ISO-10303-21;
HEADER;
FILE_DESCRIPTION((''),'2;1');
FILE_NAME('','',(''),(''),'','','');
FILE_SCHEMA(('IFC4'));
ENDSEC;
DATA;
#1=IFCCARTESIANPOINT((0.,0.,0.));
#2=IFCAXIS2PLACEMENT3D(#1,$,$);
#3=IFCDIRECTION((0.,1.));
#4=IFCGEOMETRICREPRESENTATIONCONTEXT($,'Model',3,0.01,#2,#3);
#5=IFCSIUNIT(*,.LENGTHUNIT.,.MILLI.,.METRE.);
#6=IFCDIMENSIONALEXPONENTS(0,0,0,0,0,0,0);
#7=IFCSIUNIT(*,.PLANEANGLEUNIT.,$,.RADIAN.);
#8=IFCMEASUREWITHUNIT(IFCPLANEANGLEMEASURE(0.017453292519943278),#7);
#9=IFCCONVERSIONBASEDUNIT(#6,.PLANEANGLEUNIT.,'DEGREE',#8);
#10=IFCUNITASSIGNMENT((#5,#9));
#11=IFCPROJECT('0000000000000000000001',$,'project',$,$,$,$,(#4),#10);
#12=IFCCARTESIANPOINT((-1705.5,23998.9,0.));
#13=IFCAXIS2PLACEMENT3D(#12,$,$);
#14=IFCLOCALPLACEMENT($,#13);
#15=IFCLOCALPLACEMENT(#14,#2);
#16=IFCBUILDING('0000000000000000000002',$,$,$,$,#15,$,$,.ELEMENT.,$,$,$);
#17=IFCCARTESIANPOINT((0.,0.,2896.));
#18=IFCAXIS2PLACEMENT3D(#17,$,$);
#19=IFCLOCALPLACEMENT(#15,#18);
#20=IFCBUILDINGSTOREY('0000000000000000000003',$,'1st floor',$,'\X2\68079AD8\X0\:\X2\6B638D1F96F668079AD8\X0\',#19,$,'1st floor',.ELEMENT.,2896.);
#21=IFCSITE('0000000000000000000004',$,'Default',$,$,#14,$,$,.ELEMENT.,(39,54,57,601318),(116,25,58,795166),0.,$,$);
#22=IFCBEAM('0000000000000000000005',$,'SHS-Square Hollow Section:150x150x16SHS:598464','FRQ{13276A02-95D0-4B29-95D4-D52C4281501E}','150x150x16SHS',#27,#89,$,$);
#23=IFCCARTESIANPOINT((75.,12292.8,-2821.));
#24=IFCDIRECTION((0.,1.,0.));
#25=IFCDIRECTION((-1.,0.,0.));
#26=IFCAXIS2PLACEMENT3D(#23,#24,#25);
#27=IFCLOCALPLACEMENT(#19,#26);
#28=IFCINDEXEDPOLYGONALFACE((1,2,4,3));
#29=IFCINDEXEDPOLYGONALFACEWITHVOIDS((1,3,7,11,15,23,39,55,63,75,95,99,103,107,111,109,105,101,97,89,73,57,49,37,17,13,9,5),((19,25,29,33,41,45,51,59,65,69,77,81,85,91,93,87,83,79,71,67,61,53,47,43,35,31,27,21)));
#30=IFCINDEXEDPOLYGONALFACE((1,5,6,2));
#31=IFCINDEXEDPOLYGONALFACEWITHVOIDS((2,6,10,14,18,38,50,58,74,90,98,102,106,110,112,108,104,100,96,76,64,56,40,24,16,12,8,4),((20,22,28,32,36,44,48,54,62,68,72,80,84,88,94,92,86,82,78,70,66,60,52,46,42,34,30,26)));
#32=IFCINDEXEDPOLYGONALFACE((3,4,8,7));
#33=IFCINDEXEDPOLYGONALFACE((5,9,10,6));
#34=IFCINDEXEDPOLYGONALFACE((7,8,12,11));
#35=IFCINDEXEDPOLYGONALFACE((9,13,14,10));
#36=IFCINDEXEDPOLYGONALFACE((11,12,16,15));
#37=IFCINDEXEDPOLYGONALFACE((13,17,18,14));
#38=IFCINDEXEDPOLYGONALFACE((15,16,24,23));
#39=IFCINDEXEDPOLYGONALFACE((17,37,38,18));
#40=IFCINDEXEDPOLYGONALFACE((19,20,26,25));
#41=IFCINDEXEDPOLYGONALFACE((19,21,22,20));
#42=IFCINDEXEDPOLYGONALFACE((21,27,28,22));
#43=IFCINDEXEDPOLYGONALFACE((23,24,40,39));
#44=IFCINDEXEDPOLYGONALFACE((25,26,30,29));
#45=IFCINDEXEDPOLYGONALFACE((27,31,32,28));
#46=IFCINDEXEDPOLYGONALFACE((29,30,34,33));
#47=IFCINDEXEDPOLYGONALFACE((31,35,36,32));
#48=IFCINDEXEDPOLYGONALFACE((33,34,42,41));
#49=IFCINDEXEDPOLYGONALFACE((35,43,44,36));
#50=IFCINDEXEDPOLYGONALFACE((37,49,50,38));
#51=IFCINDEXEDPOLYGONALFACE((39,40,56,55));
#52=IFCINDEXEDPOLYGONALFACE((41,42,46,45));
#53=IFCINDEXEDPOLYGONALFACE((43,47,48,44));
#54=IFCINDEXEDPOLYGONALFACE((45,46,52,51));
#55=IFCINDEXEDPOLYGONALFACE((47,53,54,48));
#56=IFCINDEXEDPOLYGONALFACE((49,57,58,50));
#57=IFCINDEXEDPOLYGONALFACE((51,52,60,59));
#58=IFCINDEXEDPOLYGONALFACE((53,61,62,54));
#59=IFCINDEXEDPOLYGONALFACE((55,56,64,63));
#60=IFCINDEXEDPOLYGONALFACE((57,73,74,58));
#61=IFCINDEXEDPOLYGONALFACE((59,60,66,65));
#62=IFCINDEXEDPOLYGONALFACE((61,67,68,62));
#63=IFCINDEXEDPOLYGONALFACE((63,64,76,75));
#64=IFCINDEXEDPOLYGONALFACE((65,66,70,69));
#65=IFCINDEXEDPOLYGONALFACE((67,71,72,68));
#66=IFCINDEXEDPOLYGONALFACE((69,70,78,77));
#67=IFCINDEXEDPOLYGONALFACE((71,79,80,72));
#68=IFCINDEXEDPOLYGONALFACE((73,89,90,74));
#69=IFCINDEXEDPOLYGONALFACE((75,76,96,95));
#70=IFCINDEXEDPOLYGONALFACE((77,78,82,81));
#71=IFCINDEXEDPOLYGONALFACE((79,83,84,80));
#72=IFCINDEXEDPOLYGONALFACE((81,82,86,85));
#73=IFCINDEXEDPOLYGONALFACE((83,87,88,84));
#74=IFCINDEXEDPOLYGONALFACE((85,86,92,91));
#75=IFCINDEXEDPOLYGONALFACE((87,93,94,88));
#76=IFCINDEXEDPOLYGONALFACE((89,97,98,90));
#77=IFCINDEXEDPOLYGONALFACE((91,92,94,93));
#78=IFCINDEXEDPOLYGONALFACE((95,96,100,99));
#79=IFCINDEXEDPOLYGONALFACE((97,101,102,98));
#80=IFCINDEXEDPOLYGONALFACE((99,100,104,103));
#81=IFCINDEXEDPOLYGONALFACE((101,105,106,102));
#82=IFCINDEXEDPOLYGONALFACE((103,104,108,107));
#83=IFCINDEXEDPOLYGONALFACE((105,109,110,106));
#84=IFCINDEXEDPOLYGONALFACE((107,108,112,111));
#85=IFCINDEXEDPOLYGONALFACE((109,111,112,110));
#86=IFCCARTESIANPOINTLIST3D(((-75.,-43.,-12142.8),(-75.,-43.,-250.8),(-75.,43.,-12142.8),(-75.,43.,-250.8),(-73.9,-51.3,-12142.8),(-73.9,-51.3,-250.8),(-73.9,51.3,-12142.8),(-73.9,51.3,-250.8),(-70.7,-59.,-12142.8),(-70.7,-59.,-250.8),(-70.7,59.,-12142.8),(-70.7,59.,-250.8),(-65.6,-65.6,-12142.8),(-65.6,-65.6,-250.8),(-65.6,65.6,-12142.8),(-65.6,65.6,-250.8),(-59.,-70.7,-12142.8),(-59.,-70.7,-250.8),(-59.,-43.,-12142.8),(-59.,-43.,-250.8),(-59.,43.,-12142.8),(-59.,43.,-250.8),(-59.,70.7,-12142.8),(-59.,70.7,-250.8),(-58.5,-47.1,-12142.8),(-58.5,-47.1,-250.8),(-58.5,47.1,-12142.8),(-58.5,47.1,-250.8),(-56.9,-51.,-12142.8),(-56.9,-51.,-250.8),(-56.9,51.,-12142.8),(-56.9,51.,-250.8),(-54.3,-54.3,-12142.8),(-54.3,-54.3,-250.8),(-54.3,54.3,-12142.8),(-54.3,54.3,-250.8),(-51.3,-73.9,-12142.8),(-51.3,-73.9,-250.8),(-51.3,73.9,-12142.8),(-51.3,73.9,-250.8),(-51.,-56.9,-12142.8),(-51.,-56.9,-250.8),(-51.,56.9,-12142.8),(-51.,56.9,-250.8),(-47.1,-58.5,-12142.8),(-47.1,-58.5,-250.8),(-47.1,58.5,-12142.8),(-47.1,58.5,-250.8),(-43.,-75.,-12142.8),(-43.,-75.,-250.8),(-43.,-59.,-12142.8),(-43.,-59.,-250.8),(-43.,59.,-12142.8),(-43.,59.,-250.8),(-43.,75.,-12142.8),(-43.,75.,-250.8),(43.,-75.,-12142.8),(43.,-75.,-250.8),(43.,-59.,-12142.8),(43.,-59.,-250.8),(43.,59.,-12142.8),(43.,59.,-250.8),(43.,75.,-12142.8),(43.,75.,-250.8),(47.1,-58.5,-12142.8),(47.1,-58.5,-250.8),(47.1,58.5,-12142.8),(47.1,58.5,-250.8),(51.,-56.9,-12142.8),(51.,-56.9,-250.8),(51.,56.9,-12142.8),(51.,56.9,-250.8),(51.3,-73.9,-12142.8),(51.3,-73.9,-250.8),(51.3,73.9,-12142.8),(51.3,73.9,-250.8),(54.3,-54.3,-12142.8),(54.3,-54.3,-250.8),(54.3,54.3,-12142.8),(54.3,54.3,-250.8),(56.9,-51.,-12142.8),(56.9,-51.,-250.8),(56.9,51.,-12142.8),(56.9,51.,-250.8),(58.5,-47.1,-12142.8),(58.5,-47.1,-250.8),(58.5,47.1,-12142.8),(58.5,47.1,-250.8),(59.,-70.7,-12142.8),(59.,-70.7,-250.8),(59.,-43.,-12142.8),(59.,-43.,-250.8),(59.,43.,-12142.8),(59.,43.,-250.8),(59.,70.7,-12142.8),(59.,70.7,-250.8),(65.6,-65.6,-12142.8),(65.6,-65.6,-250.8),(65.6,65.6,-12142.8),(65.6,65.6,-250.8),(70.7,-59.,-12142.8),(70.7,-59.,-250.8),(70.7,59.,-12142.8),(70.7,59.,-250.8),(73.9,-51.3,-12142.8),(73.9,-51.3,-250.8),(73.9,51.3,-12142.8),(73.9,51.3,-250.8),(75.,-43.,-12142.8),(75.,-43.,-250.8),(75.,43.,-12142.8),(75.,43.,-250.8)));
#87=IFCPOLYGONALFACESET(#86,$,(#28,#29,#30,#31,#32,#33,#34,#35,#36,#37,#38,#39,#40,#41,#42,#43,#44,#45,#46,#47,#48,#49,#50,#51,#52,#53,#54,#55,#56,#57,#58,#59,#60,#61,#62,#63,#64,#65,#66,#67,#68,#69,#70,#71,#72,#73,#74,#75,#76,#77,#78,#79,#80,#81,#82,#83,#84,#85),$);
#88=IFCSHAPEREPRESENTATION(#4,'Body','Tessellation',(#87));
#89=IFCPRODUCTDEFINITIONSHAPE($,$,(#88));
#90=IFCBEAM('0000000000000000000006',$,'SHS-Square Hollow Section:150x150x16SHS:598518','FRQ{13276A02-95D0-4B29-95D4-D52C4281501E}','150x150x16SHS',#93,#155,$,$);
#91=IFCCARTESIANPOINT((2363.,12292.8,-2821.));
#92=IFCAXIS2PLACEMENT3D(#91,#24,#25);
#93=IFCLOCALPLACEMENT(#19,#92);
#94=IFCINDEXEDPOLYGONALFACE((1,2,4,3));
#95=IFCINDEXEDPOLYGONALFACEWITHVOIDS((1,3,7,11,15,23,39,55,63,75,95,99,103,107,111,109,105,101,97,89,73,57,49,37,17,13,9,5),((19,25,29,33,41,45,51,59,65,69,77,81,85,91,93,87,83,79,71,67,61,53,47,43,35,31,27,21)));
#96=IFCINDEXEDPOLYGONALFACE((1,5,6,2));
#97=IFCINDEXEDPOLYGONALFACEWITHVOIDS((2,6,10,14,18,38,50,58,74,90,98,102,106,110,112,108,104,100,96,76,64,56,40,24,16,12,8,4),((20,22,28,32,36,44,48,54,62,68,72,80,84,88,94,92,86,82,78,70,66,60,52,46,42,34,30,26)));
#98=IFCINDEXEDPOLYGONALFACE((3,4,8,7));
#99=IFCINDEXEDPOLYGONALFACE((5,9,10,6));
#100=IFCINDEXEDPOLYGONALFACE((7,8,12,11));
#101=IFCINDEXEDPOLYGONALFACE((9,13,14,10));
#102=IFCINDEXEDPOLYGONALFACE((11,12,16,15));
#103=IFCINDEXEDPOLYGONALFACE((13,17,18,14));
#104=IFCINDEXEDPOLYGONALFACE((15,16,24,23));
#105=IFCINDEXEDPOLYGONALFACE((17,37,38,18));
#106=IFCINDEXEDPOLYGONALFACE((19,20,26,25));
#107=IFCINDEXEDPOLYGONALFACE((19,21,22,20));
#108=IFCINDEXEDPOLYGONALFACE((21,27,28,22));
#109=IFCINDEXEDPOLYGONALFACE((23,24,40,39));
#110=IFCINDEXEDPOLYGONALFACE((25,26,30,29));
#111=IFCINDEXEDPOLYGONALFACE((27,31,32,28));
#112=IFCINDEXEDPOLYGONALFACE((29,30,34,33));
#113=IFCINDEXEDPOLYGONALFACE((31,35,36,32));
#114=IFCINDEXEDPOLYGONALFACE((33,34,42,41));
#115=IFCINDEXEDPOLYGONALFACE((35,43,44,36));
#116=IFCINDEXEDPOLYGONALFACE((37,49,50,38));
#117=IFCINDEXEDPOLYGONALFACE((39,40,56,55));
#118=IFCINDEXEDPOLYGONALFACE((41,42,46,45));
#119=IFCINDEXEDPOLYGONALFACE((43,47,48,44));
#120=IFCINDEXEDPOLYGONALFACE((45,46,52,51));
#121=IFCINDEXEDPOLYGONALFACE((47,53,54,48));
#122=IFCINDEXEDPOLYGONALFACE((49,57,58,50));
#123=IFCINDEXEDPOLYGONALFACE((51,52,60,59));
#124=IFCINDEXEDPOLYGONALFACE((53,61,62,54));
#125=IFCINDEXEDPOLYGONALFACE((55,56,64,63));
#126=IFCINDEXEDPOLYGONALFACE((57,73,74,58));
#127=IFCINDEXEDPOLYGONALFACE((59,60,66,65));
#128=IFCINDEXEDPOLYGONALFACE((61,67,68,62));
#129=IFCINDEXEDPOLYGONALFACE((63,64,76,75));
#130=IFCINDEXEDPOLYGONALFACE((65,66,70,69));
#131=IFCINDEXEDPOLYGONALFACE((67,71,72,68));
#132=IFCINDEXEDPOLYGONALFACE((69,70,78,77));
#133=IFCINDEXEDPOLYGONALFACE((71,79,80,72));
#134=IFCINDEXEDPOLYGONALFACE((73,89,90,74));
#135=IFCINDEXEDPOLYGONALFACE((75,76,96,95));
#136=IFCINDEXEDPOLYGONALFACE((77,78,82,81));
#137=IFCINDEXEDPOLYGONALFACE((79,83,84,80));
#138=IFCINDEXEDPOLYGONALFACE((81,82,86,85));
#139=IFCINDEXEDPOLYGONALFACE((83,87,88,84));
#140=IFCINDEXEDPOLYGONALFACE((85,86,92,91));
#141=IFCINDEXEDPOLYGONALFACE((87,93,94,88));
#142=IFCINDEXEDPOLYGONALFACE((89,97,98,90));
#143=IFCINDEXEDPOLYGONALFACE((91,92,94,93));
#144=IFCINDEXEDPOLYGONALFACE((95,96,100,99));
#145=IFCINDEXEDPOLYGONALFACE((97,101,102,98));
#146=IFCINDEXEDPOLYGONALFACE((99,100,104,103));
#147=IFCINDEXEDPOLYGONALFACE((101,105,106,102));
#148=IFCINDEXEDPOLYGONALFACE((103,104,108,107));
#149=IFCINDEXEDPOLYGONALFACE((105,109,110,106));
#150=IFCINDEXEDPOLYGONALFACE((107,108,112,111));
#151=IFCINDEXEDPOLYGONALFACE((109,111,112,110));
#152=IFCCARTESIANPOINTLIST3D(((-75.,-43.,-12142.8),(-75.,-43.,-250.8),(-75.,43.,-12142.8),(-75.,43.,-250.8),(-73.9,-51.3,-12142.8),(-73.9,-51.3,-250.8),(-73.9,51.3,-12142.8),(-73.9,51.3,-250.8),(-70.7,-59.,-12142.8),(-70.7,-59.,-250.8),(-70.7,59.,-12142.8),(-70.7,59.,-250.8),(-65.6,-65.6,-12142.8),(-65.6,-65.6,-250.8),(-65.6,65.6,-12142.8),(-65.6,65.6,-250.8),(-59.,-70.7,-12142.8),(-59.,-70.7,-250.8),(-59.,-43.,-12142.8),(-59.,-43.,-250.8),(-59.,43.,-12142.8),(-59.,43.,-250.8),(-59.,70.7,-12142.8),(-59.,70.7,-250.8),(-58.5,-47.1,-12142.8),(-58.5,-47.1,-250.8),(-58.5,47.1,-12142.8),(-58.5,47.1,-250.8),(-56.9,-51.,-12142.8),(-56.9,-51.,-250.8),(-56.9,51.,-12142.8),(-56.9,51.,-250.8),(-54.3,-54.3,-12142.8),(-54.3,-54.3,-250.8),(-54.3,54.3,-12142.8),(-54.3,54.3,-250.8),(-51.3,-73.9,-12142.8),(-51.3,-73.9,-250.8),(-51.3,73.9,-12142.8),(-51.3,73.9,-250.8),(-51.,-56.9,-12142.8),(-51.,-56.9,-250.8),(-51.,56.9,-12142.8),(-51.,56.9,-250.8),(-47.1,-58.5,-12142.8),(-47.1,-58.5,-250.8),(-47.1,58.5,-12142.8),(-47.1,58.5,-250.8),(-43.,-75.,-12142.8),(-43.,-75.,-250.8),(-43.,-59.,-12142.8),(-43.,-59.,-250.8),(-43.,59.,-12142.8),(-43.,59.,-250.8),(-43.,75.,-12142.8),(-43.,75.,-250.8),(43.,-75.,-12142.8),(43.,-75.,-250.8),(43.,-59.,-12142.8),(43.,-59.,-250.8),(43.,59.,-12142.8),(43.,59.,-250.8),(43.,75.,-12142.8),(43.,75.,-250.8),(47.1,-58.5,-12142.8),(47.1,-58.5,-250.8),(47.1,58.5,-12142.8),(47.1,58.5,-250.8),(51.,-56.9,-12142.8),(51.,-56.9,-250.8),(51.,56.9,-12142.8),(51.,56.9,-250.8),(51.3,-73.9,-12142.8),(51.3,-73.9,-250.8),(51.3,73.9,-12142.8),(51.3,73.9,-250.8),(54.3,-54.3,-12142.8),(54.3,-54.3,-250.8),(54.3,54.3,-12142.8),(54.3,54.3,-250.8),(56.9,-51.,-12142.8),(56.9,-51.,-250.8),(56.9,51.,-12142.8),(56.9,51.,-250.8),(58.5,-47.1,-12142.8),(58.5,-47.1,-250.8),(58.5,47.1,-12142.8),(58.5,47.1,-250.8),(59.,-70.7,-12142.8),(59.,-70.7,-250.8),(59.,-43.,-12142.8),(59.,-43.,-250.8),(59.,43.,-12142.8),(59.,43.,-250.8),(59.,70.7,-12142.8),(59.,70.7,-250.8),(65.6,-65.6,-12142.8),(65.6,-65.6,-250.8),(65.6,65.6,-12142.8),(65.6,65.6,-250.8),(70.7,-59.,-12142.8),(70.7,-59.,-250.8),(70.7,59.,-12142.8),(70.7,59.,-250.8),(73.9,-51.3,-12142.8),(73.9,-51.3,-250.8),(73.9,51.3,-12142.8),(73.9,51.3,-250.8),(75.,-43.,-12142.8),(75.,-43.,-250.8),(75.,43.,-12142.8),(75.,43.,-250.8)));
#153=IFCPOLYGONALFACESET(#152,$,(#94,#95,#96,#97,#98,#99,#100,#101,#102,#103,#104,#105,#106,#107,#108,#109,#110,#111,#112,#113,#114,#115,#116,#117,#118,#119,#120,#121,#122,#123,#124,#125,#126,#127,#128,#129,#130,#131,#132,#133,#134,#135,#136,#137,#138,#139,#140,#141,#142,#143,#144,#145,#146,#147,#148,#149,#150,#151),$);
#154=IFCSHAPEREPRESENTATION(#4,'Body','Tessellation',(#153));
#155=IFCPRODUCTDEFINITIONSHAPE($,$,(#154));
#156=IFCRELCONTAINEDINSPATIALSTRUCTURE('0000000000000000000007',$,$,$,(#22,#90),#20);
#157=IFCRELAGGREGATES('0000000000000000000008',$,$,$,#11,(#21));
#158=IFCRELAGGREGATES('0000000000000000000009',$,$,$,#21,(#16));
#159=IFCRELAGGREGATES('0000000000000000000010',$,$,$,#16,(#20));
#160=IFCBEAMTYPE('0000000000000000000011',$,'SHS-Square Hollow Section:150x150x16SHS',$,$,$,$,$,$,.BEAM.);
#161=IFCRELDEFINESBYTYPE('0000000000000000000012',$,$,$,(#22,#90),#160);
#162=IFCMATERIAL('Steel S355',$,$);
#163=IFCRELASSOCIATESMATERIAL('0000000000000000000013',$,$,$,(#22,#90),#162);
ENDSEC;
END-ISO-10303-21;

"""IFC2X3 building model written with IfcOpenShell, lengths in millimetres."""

from ifc_helpers import new_model, entity, si_unit, converted_unit, direction, frame, origin, origin_2d, place, context, project, spatial, hollow_rectangle, extrude, clip, halfspace, material, type_object, element, save


model = new_model("IFC2X3")

# Units and contexts
model_context = context("Model", 3, precision=0.01, world=origin(), true_north=direction((0.0, 1.0)))
ifc_project = project(units=[si_unit("LENGTHUNIT", "METRE", prefix="MILLI"), converted_unit("PLANEANGLEUNIT", "DEGREE", entity("IfcPlaneAngleMeasure", 0.017453292519943278), si_unit("PLANEANGLEUNIT", "RADIAN"), dimensions=[0, 0, 0, 0, 0, 0, 0])], contexts=[model_context])

# Site, building, storey
site_placement = place(None, frame((-1705.5, 23998.9, 0.0)))
site = spatial("IfcSite", under=ifc_project, at=site_placement, Name="Default", CompositionType="ELEMENT", RefLatitude=(39, 54, 57, 601318), RefLongitude=(116, 25, 58, 795166), RefElevation=0.0)
building_placement = place(site_placement, origin())
building = spatial("IfcBuilding", under=site, at=building_placement, CompositionType="ELEMENT")
storey_placement = place(building_placement, frame((0.0, 0.0, 2896.0)))
storey = spatial("IfcBuildingStorey", under=building, at=storey_placement, Name="1st floor", ObjectType="标高:正负零标高", LongName="1st floor", CompositionType="ELEMENT", Elevation=2896.0)

# Shared definitions
ifc_material_1 = material(Name="Steel S355")

# Shared definitions
beam_type_1 = type_object("IfcBeamType", Name="SHS-Square Hollow Section:150x150x16SHS", PredefinedType="BEAM")

# Beams
beam_1_placement = place(storey_placement, frame((75.0, 12292.8, -2821.0), z_axis=(0.0, 1.0, 0.0), x_axis=(-1.0, 0.0, 0.0)))
element("IfcBeam", 1, at=beam_1_placement, inside=storey, type_object=beam_type_1, material=ifc_material_1, Name="SHS-Square Hollow Section:150x150x16SHS:598464", Description="FRQ{13276A02-95D0-4B29-95D4-D52C4281501E}", ObjectType="150x150x16SHS", context=model_context, shape_type="Clipping", body=[
    clip(clip(extrude(hollow_rectangle(XDim=150.0, YDim=150.0, WallThickness=16.0, InnerFilletRadius=16.0, OuterFilletRadius=32.0, at=origin_2d()), origin(), (0.0, 0.0, -1.0), 12398.9), halfspace(frame((75.0, -75.0, -12142.8), z_axis=(0.0, 0.0, 1.0), x_axis=(1.0, 0.0, 0.0)), True)), halfspace(frame((75.0, -75.0, -250.8), z_axis=(0.0, 0.0, -1.0), x_axis=(-1.0, 0.0, 0.0)), True)),
])
beam_2_placement = place(storey_placement, frame((2363.0, 12292.8, -2821.0), z_axis=(0.0, 1.0, 0.0), x_axis=(-1.0, 0.0, 0.0)))
element("IfcBeam", 2, at=beam_2_placement, inside=storey, type_object=beam_type_1, material=ifc_material_1, Name="SHS-Square Hollow Section:150x150x16SHS:598518", Description="FRQ{13276A02-95D0-4B29-95D4-D52C4281501E}", ObjectType="150x150x16SHS", context=model_context, shape_type="Clipping", body=[
    clip(clip(extrude(hollow_rectangle(XDim=150.0, YDim=150.0, WallThickness=16.0, InnerFilletRadius=16.0, OuterFilletRadius=32.0, at=origin_2d()), origin(), (0.0, 0.0, -1.0), 12398.9), halfspace(frame((2363.0, -75.0, -12142.8), z_axis=(0.0, 0.0, 1.0), x_axis=(1.0, 0.0, 0.0)), True)), halfspace(frame((2363.0, -75.0, -250.8), z_axis=(0.0, 0.0, -1.0), x_axis=(-1.0, 0.0, 0.0)), True)),
])

save(model, "model.ifc")
